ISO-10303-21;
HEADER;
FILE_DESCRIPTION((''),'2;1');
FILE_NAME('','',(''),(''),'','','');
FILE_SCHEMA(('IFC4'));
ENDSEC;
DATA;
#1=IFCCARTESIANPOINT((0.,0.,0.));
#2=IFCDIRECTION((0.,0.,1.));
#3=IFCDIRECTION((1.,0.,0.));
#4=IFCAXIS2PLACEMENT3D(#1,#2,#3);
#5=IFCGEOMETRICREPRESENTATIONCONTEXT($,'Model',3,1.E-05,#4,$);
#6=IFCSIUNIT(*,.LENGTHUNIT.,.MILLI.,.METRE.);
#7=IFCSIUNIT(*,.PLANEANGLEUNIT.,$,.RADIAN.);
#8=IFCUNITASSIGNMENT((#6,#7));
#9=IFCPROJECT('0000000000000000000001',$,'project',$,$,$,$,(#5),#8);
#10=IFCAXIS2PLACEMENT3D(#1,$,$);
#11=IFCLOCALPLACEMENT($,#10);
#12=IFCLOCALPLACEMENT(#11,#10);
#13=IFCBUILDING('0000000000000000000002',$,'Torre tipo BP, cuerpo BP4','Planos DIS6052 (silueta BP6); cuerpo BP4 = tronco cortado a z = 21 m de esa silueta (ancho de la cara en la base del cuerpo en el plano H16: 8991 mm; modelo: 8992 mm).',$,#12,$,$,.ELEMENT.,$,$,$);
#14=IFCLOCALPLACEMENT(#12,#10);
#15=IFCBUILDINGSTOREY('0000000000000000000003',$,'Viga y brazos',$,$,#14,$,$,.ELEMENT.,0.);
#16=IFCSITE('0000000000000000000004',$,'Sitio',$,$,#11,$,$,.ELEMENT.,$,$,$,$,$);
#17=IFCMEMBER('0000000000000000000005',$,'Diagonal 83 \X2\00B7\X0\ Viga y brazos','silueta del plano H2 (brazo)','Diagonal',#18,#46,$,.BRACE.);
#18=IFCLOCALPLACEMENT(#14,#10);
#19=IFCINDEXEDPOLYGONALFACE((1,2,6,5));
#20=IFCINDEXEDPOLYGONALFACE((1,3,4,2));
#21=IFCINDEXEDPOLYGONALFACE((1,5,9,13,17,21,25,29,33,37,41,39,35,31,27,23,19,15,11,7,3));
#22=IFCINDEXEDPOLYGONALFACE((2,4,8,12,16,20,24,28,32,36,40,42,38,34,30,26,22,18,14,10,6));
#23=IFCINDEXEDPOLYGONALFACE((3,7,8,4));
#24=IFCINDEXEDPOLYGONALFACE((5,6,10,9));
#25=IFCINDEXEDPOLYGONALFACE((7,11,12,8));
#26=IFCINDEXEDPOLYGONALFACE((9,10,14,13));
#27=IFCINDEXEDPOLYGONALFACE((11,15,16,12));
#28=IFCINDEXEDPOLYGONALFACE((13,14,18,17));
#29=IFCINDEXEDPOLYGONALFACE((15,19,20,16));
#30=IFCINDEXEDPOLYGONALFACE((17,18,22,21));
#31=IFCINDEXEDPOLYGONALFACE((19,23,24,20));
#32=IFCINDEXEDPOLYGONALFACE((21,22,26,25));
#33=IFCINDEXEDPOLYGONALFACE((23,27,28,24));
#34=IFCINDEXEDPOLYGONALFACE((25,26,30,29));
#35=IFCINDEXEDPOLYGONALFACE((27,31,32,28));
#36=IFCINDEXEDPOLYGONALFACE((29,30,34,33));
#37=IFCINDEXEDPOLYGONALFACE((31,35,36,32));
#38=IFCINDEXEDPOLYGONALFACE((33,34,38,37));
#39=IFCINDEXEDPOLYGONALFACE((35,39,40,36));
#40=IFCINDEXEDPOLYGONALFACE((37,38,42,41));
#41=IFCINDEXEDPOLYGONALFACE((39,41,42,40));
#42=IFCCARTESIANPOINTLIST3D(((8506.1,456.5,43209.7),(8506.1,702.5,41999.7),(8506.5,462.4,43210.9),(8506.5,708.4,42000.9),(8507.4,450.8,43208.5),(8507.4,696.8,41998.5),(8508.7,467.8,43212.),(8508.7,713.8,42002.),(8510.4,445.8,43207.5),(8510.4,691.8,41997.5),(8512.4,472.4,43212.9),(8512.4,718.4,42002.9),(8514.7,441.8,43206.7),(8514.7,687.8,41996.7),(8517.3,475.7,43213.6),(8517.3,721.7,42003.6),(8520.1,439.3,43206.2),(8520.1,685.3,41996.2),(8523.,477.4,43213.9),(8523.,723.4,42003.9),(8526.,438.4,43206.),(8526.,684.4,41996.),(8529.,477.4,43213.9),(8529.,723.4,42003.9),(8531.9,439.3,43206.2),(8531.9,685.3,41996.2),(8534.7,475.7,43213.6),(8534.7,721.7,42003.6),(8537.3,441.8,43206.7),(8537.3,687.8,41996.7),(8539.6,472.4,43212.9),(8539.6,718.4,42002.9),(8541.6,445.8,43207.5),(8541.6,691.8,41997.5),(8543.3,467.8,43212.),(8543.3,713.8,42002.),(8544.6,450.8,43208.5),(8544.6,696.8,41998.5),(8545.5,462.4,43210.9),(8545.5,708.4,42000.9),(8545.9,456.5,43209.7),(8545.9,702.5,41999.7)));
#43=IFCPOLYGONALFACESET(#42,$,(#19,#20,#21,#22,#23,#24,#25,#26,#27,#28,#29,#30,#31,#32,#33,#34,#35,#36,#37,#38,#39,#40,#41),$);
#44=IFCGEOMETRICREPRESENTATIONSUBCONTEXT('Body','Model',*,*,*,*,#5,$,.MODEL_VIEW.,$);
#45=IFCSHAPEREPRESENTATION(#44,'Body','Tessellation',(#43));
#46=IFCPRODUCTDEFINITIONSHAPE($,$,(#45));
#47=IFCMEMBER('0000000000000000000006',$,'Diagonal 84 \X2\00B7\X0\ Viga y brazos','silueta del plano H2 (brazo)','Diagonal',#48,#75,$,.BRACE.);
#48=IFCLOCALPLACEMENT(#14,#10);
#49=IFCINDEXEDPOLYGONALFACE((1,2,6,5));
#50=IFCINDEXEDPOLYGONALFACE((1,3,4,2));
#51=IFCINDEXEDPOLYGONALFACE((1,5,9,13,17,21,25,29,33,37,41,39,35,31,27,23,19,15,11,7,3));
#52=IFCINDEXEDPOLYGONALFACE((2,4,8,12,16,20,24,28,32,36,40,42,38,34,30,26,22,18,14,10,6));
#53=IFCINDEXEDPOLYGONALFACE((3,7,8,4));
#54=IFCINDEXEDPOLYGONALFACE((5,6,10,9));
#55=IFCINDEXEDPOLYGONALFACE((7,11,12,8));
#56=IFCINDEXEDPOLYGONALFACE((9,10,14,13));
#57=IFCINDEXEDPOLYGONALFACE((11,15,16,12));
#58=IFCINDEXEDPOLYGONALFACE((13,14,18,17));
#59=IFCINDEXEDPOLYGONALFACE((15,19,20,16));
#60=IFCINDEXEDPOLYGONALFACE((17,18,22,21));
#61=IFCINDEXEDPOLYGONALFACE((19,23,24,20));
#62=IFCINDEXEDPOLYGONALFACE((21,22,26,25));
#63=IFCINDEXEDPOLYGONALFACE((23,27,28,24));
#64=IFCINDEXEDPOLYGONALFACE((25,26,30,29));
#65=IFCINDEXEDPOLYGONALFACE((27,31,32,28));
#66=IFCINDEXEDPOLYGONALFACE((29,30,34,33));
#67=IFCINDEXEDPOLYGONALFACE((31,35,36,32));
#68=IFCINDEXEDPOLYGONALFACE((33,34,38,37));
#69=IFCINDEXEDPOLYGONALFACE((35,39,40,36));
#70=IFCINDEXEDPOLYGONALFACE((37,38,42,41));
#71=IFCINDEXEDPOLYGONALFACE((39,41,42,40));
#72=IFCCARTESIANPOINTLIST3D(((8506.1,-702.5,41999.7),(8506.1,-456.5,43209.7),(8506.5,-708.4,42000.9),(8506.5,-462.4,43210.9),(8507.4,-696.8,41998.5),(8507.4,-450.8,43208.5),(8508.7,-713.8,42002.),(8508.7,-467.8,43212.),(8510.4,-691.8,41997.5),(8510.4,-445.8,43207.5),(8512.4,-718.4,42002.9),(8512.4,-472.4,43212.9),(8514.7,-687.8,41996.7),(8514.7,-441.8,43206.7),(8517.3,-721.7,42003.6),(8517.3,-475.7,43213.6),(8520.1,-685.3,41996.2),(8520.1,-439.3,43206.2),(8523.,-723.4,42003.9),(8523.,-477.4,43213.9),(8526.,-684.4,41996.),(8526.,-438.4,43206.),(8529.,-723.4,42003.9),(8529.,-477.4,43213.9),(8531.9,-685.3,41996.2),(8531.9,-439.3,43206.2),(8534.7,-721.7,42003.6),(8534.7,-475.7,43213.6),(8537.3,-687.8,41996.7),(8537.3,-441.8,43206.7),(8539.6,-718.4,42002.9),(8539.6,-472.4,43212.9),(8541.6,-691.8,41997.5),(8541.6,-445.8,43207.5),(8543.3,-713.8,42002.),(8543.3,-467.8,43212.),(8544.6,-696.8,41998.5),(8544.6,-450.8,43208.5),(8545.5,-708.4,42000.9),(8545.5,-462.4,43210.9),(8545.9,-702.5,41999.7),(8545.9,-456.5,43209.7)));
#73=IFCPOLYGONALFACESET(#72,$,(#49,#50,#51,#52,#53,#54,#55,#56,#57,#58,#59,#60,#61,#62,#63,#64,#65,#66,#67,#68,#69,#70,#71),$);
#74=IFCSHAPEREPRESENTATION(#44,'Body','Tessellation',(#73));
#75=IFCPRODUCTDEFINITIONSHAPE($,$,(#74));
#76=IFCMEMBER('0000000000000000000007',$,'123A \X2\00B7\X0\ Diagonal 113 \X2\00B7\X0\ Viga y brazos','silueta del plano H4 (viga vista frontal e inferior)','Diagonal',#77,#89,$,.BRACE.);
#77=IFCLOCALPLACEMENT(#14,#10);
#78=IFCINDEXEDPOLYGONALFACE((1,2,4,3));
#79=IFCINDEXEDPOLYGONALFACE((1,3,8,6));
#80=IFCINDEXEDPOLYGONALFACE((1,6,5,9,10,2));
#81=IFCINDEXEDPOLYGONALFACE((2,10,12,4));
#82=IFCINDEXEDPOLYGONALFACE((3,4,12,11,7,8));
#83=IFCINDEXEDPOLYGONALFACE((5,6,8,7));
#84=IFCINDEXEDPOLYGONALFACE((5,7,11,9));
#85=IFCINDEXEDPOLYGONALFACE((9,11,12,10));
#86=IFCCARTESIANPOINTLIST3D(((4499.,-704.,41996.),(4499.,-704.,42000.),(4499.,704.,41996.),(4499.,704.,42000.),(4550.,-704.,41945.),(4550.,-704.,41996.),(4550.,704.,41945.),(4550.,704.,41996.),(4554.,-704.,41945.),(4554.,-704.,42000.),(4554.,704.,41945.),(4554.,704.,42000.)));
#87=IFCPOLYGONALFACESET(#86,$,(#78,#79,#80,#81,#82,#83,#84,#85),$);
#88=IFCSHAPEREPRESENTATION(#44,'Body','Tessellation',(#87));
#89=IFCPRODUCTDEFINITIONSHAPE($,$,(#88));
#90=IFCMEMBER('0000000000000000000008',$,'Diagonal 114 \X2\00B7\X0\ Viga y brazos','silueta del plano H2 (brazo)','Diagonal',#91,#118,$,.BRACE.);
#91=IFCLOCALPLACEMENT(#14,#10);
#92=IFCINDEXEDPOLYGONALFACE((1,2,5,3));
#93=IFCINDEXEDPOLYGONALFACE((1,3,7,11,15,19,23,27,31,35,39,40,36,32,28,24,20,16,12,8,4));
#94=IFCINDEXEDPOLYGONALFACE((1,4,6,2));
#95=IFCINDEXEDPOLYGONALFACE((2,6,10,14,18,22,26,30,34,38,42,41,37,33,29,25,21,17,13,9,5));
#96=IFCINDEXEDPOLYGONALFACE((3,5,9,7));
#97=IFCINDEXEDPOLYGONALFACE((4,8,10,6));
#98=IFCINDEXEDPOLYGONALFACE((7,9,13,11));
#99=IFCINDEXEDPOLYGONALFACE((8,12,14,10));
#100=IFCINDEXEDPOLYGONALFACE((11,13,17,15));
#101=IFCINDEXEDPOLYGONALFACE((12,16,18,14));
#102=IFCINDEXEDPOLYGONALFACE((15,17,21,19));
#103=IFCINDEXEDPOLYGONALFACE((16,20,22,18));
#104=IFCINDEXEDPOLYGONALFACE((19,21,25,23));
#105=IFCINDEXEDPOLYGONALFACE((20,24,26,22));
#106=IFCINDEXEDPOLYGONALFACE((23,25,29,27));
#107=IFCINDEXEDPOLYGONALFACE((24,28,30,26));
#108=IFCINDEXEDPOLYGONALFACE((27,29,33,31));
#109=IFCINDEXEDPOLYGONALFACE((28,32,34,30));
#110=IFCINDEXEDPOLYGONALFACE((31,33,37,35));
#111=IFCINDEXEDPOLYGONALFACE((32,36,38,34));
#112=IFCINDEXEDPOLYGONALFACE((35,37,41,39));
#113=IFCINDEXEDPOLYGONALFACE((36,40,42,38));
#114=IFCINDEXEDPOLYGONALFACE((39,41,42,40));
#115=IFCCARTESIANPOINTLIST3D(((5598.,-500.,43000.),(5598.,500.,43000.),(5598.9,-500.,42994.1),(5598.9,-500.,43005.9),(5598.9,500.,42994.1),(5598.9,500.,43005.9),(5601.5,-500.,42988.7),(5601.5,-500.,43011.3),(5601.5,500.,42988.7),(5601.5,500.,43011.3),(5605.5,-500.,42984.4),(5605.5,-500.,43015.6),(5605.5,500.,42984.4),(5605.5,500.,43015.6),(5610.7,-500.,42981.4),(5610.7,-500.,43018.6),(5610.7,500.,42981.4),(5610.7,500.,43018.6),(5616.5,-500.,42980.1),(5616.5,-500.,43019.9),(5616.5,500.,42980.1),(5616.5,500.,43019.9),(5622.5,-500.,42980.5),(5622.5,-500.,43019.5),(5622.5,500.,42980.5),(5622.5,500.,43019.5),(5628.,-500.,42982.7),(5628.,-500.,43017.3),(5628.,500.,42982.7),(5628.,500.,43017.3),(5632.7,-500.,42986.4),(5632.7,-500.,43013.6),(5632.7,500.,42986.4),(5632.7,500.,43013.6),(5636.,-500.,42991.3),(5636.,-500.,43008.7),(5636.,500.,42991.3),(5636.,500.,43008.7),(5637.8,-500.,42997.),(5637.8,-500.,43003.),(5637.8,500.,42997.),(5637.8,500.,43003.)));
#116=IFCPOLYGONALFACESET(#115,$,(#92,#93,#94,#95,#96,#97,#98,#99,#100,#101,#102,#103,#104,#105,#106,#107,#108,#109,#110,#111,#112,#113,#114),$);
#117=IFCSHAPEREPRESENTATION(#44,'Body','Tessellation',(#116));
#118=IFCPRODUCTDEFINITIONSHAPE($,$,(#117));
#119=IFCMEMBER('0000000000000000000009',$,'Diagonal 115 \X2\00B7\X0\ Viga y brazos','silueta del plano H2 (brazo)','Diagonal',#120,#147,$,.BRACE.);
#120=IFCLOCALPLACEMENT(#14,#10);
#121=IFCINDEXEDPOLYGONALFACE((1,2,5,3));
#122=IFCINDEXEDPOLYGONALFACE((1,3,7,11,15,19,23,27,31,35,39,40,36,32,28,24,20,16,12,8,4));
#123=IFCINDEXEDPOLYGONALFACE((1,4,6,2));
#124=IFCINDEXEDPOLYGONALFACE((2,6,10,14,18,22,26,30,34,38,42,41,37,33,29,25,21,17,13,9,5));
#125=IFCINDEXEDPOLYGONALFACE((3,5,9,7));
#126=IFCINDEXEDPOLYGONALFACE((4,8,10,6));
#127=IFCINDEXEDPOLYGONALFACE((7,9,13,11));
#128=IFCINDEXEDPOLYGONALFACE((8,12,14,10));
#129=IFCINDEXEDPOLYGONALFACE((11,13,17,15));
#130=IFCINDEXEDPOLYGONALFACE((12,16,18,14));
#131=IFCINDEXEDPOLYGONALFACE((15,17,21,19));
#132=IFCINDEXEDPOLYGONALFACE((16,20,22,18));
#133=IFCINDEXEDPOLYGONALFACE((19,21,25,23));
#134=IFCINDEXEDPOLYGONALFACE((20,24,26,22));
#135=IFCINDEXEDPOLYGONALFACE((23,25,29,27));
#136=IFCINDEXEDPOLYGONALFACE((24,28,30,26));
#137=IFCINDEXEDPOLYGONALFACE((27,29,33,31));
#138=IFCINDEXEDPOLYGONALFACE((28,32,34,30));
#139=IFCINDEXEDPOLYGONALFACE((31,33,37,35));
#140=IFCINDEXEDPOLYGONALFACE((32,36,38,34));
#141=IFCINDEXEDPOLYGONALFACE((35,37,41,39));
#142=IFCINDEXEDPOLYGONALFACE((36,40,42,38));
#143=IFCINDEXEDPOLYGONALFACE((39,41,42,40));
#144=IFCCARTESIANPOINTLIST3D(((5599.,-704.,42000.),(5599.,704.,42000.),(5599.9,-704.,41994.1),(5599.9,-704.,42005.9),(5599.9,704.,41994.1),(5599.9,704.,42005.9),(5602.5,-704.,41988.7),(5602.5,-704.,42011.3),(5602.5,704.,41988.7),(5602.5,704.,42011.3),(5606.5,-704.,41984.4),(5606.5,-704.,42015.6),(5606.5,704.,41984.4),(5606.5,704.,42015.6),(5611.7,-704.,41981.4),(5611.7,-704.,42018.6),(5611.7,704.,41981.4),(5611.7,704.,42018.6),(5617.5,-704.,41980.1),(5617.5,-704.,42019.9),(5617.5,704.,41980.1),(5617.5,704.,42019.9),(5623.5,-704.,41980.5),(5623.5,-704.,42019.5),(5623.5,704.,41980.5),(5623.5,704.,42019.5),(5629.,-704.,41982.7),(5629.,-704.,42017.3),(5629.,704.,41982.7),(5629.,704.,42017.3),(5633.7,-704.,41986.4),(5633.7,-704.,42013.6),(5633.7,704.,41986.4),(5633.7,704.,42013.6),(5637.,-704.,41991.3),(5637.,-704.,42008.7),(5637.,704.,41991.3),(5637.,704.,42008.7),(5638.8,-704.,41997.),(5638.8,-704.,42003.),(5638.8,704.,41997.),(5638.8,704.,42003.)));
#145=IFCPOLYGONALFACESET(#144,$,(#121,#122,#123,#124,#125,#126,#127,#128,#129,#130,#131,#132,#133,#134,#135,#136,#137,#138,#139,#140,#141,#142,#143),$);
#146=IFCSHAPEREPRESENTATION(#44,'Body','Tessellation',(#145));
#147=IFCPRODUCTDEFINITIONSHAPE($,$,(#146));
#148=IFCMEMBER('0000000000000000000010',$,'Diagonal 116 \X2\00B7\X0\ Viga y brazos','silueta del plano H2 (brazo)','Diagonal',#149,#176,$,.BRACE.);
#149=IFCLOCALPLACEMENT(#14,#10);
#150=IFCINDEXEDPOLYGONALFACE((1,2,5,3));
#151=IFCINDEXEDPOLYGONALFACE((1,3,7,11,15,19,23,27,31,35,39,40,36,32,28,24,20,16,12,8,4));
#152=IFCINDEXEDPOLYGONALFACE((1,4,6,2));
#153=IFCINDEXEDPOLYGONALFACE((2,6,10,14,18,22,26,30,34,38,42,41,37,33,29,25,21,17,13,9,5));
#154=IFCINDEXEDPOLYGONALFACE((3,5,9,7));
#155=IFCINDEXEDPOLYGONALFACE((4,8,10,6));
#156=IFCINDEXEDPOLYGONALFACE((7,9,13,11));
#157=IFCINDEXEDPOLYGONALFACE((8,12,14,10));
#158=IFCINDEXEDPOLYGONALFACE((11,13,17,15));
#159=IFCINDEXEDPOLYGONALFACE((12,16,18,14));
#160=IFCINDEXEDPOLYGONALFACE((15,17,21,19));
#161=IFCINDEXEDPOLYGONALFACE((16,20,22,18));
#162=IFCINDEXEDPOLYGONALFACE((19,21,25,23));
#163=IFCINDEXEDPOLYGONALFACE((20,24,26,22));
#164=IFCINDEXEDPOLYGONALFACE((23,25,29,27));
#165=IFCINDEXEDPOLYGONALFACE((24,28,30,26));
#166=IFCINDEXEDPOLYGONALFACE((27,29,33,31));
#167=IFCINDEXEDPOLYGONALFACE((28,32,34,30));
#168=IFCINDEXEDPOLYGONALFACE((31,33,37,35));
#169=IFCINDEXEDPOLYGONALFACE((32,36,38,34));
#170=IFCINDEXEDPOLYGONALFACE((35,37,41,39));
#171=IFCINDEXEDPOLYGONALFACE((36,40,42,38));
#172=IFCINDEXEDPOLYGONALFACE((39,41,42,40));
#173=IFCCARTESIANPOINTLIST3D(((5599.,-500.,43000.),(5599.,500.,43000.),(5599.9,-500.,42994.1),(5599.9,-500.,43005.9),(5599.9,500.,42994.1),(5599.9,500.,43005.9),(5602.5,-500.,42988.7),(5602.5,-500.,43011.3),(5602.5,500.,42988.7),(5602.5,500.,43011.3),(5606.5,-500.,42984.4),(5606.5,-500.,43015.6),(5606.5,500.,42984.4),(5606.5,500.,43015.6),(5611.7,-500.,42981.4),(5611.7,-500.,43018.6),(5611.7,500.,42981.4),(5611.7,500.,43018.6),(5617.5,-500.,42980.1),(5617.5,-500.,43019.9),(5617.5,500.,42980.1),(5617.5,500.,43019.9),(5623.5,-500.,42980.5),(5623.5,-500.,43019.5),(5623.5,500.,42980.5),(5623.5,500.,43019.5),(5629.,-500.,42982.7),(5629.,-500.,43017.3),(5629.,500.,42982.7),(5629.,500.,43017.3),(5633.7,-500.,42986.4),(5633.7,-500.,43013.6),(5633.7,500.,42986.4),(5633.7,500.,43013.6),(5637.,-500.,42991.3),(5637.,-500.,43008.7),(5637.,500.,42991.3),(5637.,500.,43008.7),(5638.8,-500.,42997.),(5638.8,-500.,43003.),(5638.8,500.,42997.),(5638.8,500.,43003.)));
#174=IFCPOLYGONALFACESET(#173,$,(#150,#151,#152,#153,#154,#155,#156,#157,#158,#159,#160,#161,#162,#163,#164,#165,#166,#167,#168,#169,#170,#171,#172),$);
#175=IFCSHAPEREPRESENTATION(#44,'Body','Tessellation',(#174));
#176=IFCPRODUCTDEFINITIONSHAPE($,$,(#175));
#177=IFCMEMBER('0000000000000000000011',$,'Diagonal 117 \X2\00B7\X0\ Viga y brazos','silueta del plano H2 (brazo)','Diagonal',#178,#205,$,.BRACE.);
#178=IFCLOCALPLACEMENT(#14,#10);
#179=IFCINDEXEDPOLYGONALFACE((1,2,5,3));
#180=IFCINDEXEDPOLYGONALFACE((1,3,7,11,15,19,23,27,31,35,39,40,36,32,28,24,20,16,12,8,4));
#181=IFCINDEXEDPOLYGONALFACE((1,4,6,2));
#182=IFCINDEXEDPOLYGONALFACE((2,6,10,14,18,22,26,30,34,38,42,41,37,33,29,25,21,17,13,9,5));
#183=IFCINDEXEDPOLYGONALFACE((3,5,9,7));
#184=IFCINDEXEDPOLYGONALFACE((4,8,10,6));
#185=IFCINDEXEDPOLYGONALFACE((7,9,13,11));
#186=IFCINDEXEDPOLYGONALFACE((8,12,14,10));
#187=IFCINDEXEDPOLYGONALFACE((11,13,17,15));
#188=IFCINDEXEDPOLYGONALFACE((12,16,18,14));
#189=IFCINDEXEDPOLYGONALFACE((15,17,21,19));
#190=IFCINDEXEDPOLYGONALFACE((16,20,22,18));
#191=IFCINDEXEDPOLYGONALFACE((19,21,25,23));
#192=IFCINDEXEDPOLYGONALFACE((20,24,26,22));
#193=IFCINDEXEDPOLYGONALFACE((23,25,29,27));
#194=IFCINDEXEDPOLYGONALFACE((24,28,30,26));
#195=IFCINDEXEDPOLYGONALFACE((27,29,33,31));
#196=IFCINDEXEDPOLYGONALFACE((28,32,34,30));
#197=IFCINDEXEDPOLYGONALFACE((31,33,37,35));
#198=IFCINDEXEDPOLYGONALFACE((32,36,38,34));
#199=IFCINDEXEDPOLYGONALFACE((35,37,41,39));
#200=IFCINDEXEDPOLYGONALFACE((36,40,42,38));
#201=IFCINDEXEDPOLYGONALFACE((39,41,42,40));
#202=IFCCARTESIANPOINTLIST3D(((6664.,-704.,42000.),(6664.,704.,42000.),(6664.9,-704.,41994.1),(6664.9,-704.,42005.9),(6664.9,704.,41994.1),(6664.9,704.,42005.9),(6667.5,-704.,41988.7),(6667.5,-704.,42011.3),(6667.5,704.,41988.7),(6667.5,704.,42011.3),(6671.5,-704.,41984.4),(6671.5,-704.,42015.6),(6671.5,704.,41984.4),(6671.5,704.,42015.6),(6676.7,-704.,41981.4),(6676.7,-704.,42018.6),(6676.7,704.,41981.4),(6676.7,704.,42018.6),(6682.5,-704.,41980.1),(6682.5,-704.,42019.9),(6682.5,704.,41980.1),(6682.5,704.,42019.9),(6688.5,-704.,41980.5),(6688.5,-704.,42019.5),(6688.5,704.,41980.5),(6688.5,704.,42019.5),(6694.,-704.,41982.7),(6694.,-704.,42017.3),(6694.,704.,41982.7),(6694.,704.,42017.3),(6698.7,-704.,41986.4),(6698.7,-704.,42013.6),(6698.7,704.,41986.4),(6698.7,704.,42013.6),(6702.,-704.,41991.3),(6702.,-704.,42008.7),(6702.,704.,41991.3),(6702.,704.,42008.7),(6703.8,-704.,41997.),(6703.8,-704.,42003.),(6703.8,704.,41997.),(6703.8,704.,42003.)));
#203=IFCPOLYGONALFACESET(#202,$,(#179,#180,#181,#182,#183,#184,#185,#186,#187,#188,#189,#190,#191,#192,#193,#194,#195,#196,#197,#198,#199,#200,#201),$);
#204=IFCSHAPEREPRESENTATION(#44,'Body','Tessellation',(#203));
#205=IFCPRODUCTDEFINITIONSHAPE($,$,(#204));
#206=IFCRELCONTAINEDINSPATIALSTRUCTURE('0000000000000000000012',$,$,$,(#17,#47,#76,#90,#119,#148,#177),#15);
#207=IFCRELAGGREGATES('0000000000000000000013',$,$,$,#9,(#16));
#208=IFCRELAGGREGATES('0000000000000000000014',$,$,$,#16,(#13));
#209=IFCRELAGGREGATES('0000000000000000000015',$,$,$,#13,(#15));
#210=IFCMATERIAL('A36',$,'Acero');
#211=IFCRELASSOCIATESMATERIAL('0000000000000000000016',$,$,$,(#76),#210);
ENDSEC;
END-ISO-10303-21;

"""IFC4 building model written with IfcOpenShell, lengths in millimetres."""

from ifc_helpers import new_model, si_unit, frame, frame_2d, origin, origin_with_axes, place, context, subcontext, project, spatial, circle, l_section, extrude, material, element, save


model = new_model("IFC4")

# Units and contexts
model_context = context("Model", 3, precision=1e-05, world=origin_with_axes())
body_context = subcontext(model_context, "Body", "Model", "MODEL_VIEW")
ifc_project = project(units=[si_unit("LENGTHUNIT", "METRE", prefix="MILLI"), si_unit("PLANEANGLEUNIT", "RADIAN")], contexts=[model_context])

# Site, building, storey
site_placement = place(None, origin())
site = spatial("IfcSite", under=ifc_project, at=site_placement, Name="Sitio", CompositionType="ELEMENT")
building_placement = place(site_placement, origin())
building = spatial("IfcBuilding", under=site, at=building_placement, Name="Torre tipo BP, cuerpo BP4", Description="Planos DIS6052 (silueta BP6); cuerpo BP4 = tronco cortado a z = 21 m de esa silueta (ancho de la cara en la base del cuerpo en el plano H16: 8991 mm; modelo: 8992 mm).", CompositionType="ELEMENT")
storey_placement = place(building_placement, origin())
storey = spatial("IfcBuildingStorey", under=building, at=storey_placement, Name="Viga y brazos", CompositionType="ELEMENT", Elevation=0.0)

# Members
ifc_material_1 = material(Name="A36", Category="Acero")
for number, where, z_axis, x_axis, name in (
    (1, (8526.0, 458.0, 43210.0), (0.0, 0.19923, -0.979953), (0.0, -0.979953, -0.19923), "Diagonal 83 · Viga y brazos"),
    (2, (8526.0, -458.0, 43210.0), (0.0, -0.19923, -0.979953), (0.0, 0.979953, -0.19923), "Diagonal 84 · Viga y brazos"),
):
    element("IfcMember", number, at=place(storey_placement, frame(where, z_axis=z_axis, x_axis=x_axis)), inside=storey, Name=name, Description="silueta del plano H2 (brazo)", ObjectType="Diagonal", PredefinedType="BRACE", context=body_context, shape_type="SweptSolid", body=[
        extrude(circle(Radius=20.0), None, (0.0, 0.0, 1.0), 1234.8),
    ])
member_1_placement = place(storey_placement, frame((4554.0, 704.0, 42000.0), z_axis=(0.0, -1.0, 0.0), x_axis=(-1.0, 0.0, 0.0)))
element("IfcMember", 3, at=member_1_placement, inside=storey, material=ifc_material_1, Name="123A · Diagonal 113 · Viga y brazos", Description="silueta del plano H4 (viga vista frontal e inferior)", ObjectType="Diagonal", PredefinedType="BRACE", context=body_context, shape_type="SweptSolid", body=[
    extrude(l_section(Depth=55.0, Width=55.0, Thickness=4.0, at=frame_2d((27.5, 27.5))), None, (0.0, 0.0, 1.0), 1408.0),
])
member_2_placement = place(storey_placement, frame((5618.0, 500.0, 43000.0), z_axis=(0.0, -1.0, 0.0), x_axis=(-1.0, 0.0, 0.0)))
element("IfcMember", 4, at=member_2_placement, inside=storey, Name="Diagonal 114 · Viga y brazos", Description="silueta del plano H2 (brazo)", ObjectType="Diagonal", PredefinedType="BRACE", context=body_context, shape_type="SweptSolid", body=[
    extrude(circle(Radius=20.0), None, (0.0, 0.0, 1.0), 1000.0),
])
member_3_placement = place(storey_placement, frame((5619.0, 704.0, 42000.0), z_axis=(0.0, -1.0, 0.0), x_axis=(-1.0, 0.0, 0.0)))
element("IfcMember", 5, at=member_3_placement, inside=storey, Name="Diagonal 115 · Viga y brazos", Description="silueta del plano H2 (brazo)", ObjectType="Diagonal", PredefinedType="BRACE", context=body_context, shape_type="SweptSolid", body=[
    extrude(circle(Radius=20.0), None, (0.0, 0.0, 1.0), 1408.0),
])
member_4_placement = place(storey_placement, frame((5619.0, 500.0, 43000.0), z_axis=(0.0, -1.0, 0.0), x_axis=(-1.0, 0.0, 0.0)))
element("IfcMember", 6, at=member_4_placement, inside=storey, Name="Diagonal 116 · Viga y brazos", Description="silueta del plano H2 (brazo)", ObjectType="Diagonal", PredefinedType="BRACE", context=body_context, shape_type="SweptSolid", body=[
    extrude(circle(Radius=20.0), None, (0.0, 0.0, 1.0), 1000.0),
])
member_5_placement = place(storey_placement, frame((6684.0, 704.0, 42000.0), z_axis=(0.0, -1.0, 0.0), x_axis=(-1.0, 0.0, 0.0)))
element("IfcMember", 7, at=member_5_placement, inside=storey, Name="Diagonal 117 · Viga y brazos", Description="silueta del plano H2 (brazo)", ObjectType="Diagonal", PredefinedType="BRACE", context=body_context, shape_type="SweptSolid", body=[
    extrude(circle(Radius=20.0), None, (0.0, 0.0, 1.0), 1408.0),
])

save(model, "model.ifc")
